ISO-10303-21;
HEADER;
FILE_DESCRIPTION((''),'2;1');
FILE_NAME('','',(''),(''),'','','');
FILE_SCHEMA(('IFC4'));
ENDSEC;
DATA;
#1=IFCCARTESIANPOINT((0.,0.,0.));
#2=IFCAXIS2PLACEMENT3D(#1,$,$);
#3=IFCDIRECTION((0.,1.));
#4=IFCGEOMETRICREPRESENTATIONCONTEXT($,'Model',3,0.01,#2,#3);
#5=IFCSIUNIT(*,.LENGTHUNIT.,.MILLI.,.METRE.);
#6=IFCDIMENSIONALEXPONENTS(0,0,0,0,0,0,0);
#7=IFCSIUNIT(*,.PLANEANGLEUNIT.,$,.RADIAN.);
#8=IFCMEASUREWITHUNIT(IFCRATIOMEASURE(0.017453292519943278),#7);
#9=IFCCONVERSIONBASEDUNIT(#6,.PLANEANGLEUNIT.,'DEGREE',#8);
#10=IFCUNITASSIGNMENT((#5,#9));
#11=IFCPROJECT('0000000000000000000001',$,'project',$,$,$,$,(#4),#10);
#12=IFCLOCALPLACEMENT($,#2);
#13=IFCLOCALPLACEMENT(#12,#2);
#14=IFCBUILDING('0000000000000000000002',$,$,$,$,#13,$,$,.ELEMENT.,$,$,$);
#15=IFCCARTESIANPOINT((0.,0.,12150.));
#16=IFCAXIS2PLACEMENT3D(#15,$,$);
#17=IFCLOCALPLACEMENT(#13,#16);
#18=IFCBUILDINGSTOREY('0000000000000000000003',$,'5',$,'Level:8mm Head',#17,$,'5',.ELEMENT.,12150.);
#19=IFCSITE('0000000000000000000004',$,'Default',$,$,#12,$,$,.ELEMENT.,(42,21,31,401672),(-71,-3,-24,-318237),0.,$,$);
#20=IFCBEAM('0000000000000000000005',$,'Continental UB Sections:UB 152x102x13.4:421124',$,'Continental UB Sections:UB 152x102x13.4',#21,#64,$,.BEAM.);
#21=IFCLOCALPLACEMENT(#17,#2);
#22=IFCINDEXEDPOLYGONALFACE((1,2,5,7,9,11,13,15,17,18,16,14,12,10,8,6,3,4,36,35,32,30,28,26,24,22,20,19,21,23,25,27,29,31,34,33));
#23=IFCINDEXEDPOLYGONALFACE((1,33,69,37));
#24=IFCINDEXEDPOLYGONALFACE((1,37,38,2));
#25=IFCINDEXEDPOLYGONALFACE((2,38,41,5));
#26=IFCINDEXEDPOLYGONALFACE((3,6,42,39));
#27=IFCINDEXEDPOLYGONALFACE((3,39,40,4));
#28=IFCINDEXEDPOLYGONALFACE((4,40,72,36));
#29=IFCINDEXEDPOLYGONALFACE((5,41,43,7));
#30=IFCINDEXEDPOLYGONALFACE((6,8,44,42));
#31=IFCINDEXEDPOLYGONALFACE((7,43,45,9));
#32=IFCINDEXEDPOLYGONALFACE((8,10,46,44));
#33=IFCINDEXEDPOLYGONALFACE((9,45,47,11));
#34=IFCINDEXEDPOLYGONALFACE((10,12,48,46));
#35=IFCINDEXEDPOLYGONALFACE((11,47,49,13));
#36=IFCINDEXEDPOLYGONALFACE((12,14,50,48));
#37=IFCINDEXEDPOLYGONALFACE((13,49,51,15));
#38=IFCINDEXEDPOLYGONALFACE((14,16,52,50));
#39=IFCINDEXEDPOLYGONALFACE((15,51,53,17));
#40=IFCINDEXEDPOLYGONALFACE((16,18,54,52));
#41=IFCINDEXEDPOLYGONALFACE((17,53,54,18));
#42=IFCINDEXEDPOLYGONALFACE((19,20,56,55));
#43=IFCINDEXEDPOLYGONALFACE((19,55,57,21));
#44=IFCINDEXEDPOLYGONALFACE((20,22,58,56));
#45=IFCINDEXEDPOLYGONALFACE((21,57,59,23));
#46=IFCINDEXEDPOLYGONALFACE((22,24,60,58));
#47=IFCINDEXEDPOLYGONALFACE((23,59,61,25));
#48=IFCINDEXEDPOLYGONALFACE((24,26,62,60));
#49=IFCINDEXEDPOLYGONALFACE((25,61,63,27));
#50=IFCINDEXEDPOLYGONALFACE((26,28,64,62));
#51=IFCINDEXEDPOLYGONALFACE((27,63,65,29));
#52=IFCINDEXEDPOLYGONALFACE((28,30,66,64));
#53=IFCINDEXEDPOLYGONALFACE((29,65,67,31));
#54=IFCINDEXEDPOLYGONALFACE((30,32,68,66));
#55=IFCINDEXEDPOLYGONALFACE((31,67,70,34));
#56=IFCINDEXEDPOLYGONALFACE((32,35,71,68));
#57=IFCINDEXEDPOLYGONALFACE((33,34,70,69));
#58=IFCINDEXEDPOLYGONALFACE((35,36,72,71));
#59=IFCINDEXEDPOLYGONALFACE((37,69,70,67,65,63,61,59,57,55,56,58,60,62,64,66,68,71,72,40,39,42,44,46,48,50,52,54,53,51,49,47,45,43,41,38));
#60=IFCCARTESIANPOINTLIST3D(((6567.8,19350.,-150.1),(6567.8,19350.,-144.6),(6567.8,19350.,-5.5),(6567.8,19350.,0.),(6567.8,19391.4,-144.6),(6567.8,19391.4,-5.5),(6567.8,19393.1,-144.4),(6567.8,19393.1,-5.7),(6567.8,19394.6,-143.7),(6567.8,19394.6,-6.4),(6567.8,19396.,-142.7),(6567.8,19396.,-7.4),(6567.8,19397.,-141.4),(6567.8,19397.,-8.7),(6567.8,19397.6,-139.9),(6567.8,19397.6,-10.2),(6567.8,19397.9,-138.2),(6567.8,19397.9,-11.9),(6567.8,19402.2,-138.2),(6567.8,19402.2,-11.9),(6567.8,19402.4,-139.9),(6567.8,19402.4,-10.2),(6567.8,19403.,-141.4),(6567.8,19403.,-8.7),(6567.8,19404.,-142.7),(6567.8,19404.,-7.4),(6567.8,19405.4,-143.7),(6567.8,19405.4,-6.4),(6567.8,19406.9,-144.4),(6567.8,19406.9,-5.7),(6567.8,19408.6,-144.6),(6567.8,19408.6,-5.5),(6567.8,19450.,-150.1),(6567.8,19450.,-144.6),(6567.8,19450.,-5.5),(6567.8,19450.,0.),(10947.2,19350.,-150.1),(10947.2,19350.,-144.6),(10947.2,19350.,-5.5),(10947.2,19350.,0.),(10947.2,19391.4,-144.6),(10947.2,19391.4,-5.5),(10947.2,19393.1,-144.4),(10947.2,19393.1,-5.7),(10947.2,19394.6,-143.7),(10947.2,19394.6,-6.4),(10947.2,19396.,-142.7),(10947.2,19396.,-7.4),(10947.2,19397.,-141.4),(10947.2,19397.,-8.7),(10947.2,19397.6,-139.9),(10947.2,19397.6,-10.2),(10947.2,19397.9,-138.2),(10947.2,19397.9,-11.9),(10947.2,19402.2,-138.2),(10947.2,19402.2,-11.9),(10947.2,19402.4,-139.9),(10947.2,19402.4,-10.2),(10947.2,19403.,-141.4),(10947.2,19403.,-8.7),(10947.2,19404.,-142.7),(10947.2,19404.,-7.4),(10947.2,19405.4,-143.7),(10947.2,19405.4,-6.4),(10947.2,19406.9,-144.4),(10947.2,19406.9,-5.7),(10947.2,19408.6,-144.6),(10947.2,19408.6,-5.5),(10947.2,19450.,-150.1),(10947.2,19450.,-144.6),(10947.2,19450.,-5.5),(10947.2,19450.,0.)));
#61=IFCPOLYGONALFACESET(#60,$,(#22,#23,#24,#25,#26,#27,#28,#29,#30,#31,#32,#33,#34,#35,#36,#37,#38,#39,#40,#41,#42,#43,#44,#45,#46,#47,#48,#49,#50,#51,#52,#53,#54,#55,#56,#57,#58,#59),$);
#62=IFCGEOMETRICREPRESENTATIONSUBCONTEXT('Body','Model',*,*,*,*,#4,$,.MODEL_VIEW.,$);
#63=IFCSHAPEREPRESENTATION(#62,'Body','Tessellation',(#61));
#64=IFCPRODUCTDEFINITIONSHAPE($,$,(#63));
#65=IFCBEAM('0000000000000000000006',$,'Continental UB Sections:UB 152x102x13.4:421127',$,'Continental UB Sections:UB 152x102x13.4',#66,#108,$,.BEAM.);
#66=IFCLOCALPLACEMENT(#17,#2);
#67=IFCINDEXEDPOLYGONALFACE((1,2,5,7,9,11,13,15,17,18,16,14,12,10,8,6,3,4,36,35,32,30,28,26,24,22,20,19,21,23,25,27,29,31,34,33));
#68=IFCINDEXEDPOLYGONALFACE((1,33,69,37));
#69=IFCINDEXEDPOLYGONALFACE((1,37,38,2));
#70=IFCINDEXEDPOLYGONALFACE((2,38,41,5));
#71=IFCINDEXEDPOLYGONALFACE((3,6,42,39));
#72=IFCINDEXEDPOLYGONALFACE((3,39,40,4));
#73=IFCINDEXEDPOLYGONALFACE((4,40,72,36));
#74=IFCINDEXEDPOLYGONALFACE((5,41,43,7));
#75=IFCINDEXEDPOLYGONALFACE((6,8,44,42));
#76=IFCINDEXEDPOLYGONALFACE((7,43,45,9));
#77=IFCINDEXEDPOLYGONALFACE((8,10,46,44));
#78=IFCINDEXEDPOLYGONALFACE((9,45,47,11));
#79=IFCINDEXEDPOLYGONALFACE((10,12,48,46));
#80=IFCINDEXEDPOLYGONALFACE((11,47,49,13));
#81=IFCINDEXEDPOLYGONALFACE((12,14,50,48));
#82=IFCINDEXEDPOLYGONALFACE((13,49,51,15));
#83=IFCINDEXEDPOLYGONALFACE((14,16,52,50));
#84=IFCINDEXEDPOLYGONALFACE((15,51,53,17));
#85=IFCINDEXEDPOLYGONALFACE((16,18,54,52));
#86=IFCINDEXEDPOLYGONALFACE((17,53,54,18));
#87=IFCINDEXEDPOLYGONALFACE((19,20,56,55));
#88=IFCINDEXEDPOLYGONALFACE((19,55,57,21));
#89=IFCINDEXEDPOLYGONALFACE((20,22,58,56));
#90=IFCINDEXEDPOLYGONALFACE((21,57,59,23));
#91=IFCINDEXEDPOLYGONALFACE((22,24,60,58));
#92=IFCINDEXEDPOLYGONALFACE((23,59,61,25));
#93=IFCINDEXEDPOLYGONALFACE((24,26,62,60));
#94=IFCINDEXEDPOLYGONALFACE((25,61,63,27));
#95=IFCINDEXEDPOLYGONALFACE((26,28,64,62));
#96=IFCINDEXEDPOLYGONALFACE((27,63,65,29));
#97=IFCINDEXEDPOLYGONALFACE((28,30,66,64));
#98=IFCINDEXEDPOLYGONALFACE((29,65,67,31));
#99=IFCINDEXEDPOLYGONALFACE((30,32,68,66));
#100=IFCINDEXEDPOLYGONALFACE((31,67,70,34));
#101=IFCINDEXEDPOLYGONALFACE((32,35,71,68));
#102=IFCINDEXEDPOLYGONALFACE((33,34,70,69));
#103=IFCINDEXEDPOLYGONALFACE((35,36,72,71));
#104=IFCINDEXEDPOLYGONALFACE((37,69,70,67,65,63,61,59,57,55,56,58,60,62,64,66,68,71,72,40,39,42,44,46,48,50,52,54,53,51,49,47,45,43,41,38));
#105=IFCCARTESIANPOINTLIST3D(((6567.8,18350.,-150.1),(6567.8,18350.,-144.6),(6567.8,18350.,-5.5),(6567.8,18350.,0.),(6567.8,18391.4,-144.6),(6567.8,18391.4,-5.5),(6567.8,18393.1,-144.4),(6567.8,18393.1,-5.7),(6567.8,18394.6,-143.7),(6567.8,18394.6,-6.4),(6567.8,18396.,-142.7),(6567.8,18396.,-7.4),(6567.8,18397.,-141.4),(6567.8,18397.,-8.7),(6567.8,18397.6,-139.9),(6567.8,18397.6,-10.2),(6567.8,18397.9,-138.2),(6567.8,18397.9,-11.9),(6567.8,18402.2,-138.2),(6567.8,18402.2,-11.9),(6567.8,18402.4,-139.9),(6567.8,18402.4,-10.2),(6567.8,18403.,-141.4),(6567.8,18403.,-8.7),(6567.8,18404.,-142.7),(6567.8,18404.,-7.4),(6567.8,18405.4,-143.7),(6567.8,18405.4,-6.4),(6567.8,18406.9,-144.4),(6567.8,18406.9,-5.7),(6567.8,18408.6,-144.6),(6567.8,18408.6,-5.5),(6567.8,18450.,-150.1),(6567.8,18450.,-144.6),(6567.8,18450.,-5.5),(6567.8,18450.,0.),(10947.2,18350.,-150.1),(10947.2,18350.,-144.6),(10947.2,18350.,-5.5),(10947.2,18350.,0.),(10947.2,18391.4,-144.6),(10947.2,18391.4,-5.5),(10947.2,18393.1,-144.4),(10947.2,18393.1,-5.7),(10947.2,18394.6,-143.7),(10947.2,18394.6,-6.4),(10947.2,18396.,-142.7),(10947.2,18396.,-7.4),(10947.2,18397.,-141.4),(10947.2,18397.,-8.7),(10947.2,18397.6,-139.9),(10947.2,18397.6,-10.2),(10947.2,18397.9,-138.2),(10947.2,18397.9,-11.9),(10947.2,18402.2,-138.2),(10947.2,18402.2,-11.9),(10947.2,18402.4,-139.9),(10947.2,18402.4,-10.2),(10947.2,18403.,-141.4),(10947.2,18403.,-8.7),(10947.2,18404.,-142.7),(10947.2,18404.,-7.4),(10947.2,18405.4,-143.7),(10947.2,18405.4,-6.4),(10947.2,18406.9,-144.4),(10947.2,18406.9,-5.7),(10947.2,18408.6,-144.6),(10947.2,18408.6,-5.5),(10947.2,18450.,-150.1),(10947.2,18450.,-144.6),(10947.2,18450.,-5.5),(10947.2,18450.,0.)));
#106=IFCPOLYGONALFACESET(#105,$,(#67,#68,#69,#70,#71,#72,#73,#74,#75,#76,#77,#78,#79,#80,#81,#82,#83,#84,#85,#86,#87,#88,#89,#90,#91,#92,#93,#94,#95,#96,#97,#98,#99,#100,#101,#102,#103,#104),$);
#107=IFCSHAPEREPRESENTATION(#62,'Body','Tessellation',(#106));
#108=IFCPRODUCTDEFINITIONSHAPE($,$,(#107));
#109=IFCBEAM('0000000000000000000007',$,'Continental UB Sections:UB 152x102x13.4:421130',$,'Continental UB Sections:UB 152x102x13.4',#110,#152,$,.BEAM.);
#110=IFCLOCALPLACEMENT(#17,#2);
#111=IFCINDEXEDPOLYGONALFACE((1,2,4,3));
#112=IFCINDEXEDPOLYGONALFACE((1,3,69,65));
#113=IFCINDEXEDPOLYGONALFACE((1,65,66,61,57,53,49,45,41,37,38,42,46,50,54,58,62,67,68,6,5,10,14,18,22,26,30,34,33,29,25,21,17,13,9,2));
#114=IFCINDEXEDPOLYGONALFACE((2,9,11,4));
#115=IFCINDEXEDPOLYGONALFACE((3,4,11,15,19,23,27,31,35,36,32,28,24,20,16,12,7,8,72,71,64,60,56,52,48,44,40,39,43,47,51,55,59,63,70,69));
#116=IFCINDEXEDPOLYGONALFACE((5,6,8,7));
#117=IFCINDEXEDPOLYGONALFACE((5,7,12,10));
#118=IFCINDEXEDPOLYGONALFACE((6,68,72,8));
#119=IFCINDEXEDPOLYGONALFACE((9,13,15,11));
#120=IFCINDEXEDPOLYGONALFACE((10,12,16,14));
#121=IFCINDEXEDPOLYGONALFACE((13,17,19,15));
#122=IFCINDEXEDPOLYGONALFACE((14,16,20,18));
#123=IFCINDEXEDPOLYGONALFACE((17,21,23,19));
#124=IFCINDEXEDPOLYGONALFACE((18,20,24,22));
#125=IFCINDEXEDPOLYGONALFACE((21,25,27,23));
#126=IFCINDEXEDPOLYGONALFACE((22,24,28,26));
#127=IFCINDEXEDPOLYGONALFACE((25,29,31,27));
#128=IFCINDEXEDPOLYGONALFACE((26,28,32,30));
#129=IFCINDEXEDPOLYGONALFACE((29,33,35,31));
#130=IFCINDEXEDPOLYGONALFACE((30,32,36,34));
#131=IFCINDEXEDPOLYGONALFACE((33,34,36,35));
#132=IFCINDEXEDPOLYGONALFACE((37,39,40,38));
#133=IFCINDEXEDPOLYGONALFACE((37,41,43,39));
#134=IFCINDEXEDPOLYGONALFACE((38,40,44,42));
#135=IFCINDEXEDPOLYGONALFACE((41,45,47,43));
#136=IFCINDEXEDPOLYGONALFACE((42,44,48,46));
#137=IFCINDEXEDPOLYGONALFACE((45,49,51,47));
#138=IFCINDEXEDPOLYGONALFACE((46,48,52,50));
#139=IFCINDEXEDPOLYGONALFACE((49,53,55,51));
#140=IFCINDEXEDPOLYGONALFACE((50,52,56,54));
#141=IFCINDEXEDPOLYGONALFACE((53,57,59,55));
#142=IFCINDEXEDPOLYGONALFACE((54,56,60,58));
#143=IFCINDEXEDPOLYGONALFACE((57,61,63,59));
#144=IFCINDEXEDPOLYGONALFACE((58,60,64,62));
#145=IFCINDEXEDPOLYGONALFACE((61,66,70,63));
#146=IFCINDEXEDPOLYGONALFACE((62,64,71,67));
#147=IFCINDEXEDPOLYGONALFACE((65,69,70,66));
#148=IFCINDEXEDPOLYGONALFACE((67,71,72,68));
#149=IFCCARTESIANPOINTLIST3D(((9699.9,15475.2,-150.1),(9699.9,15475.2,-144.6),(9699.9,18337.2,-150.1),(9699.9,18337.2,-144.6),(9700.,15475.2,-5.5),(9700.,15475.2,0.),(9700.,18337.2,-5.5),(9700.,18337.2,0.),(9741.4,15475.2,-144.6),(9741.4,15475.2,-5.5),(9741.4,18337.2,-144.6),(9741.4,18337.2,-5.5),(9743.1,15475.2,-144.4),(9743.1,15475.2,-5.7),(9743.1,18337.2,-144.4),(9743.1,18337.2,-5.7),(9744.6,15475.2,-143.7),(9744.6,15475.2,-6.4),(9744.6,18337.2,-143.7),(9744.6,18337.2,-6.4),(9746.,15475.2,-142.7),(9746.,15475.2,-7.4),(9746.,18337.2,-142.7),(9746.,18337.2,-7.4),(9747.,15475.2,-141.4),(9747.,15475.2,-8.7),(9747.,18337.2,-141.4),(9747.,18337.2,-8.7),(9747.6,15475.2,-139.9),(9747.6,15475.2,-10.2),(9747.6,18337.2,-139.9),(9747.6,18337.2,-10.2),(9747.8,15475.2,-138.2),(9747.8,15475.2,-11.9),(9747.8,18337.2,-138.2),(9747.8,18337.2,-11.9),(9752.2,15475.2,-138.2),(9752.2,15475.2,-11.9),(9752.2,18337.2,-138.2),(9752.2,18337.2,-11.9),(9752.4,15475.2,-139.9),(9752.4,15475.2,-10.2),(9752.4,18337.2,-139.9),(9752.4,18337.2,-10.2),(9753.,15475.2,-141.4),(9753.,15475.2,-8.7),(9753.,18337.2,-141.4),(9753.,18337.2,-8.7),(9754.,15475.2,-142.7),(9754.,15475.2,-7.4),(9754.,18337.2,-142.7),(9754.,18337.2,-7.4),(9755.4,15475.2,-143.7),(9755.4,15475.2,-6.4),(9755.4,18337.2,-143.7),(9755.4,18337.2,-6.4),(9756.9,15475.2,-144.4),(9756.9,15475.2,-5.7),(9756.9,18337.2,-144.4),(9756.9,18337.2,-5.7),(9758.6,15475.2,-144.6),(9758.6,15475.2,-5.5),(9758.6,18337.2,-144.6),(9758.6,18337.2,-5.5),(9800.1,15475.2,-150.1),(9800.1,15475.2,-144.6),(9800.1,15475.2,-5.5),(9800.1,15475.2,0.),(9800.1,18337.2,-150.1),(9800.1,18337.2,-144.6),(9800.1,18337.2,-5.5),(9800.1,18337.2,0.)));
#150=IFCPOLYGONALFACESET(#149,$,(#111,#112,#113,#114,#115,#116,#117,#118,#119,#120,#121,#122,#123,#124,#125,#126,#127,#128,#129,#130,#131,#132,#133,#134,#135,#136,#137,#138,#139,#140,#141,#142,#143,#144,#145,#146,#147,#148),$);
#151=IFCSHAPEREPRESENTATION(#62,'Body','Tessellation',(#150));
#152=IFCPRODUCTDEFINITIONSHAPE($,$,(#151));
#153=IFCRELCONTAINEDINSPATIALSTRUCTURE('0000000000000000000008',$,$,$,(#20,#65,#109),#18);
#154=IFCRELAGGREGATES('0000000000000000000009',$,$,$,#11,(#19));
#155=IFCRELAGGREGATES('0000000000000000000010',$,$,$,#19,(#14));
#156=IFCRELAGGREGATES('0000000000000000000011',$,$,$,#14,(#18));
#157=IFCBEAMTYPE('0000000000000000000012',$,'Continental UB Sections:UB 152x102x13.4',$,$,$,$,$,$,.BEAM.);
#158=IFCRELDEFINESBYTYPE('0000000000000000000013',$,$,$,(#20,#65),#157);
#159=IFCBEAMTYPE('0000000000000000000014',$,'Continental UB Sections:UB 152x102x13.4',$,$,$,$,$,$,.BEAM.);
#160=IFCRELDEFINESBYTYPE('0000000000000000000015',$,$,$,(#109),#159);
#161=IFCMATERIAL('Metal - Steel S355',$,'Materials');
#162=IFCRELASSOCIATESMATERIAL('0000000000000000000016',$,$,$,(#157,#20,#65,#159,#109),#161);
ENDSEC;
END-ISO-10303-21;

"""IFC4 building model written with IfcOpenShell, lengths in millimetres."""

from ifc_helpers import new_model, entity, si_unit, converted_unit, direction, frame, origin, place, context, subcontext, project, spatial, line, arc, indexed_curve, outline, extrude, source, transform, mapped, material, type_object, type_shapes, element, save


model = new_model("IFC4")

# Units and contexts
model_context = context("Model", 3, precision=0.01, world=origin(), true_north=direction((0.0, 1.0)))
body_context = subcontext(model_context, "Body", "Model", "MODEL_VIEW")
ifc_project = project(units=[si_unit("LENGTHUNIT", "METRE", prefix="MILLI"), converted_unit("PLANEANGLEUNIT", "DEGREE", entity("IfcRatioMeasure", 0.017453292519943278), si_unit("PLANEANGLEUNIT", "RADIAN"), dimensions=[0, 0, 0, 0, 0, 0, 0])], contexts=[model_context])

# Site, building, storey
site_placement = place(None, origin())
site = spatial("IfcSite", under=ifc_project, at=site_placement, Name="Default", CompositionType="ELEMENT", RefLatitude=(42, 21, 31, 401672), RefLongitude=(-71, -3, -24, -318237), RefElevation=0.0)
building_placement = place(site_placement, origin())
building = spatial("IfcBuilding", under=site, at=building_placement, CompositionType="ELEMENT")
storey_placement = place(building_placement, frame((0.0, 0.0, 12150.0)))
storey = spatial("IfcBuildingStorey", under=building, at=storey_placement, Name="5", ObjectType="Level:8mm Head", LongName="5", CompositionType="ELEMENT", Elevation=12150.0)

# Beams
ifc_material = material(Name="Metal - Steel S355", Category="Materials")
beam_type_1 = type_object("IfcBeamType", Name="Continental UB Sections:UB 152x102x13.4", PredefinedType="BEAM", material=ifc_material)
shared_shape_1 = source(origin(), body_context, "Body", "SweptSolid", [
    extrude(outline(indexed_curve([(-75.0, -50.1), (-69.6, -50.1), (-69.6, -8.5), (-67.7, -4.0), (-63.2, -2.1), (63.1, -2.1), (67.7, -4.0), (69.5, -8.5), (69.5, -50.1), (75.1, -50.1), (75.1, 50.1), (69.5, 50.1), (69.5, 8.6), (67.7, 4.0), (63.1, 2.2), (-63.2, 2.2), (-67.7, 4.0), (-69.6, 8.6), (-69.6, 50.0), (-75.0, 50.0)], segments=[line(1, 2, 3), arc(3, 4, 5), line(5, 6), arc(6, 7, 8), line(8, 9, 10, 11, 12, 13), arc(13, 14, 15), line(15, 16), arc(16, 17, 18), line(18, 19, 20, 1)], self_intersect=False)), frame((-2189.7, 0.0, 0.0), z_axis=(1.0, 0.0, 0.0), x_axis=(0.0, 0.0, -1.0)), (0.0, 0.0, 1.0), 4379.4),
])
type_shapes(beam_type_1, [shared_shape_1])
for number, where, name in (
    (1, (8757.5, 19400.0, -75.1), "Continental UB Sections:UB 152x102x13.4:421124"),
    (2, (8757.5, 18400.0, -75.1), "Continental UB Sections:UB 152x102x13.4:421127"),
):
    element("IfcBeam", number, at=place(storey_placement, frame(where)), inside=storey, type_object=beam_type_1, material=ifc_material, Name=name, ObjectType="Continental UB Sections:UB 152x102x13.4", PredefinedType="BEAM", context=body_context, shape_type="MappedRepresentation", body=[
        mapped(shared_shape_1, transform((0.0, 0.0, 0.0), scale=1.0)),
    ])
beam_type_2 = type_object("IfcBeamType", Name="Continental UB Sections:UB 152x102x13.4", PredefinedType="BEAM", material=ifc_material)
shared_shape_2 = source(origin(), body_context, "Body", "SweptSolid", [
    extrude(outline(indexed_curve([(-75.0, -50.1), (-69.6, -50.1), (-69.6, -8.5), (-67.7, -4.0), (-63.2, -2.1), (63.1, -2.1), (67.7, -4.0), (69.5, -8.5), (69.5, -50.1), (75.1, -50.1), (75.1, 50.1), (69.5, 50.1), (69.5, 8.6), (67.7, 4.0), (63.1, 2.2), (-63.2, 2.2), (-67.7, 4.0), (-69.6, 8.6), (-69.6, 50.0), (-75.0, 50.0)], segments=[line(1, 2, 3), arc(3, 4, 5), line(5, 6), arc(6, 7, 8), line(8, 9, 10, 11, 12, 13), arc(13, 14, 15), line(15, 16), arc(16, 17, 18), line(18, 19, 20, 1)], self_intersect=False)), frame((-1424.8, 0.0, 0.0), z_axis=(1.0, 0.0, 0.0), x_axis=(0.0, 0.0, -1.0)), (0.0, 0.0, 1.0), 2862.0),
])
type_shapes(beam_type_2, [shared_shape_2])
beam_1_placement = place(storey_placement, frame((9750.0, 16900.0, -75.1), z_axis=(0.0, 0.0, 1.0), x_axis=(0.0, 1.0, 0.0)))
element("IfcBeam", 3, at=beam_1_placement, inside=storey, type_object=beam_type_2, material=ifc_material, Name="Continental UB Sections:UB 152x102x13.4:421130", ObjectType="Continental UB Sections:UB 152x102x13.4", PredefinedType="BEAM", context=body_context, shape_type="MappedRepresentation", body=[
    mapped(shared_shape_2, transform((0.0, 0.0, 0.0), scale=1.0)),
])

save(model, "model.ifc")
